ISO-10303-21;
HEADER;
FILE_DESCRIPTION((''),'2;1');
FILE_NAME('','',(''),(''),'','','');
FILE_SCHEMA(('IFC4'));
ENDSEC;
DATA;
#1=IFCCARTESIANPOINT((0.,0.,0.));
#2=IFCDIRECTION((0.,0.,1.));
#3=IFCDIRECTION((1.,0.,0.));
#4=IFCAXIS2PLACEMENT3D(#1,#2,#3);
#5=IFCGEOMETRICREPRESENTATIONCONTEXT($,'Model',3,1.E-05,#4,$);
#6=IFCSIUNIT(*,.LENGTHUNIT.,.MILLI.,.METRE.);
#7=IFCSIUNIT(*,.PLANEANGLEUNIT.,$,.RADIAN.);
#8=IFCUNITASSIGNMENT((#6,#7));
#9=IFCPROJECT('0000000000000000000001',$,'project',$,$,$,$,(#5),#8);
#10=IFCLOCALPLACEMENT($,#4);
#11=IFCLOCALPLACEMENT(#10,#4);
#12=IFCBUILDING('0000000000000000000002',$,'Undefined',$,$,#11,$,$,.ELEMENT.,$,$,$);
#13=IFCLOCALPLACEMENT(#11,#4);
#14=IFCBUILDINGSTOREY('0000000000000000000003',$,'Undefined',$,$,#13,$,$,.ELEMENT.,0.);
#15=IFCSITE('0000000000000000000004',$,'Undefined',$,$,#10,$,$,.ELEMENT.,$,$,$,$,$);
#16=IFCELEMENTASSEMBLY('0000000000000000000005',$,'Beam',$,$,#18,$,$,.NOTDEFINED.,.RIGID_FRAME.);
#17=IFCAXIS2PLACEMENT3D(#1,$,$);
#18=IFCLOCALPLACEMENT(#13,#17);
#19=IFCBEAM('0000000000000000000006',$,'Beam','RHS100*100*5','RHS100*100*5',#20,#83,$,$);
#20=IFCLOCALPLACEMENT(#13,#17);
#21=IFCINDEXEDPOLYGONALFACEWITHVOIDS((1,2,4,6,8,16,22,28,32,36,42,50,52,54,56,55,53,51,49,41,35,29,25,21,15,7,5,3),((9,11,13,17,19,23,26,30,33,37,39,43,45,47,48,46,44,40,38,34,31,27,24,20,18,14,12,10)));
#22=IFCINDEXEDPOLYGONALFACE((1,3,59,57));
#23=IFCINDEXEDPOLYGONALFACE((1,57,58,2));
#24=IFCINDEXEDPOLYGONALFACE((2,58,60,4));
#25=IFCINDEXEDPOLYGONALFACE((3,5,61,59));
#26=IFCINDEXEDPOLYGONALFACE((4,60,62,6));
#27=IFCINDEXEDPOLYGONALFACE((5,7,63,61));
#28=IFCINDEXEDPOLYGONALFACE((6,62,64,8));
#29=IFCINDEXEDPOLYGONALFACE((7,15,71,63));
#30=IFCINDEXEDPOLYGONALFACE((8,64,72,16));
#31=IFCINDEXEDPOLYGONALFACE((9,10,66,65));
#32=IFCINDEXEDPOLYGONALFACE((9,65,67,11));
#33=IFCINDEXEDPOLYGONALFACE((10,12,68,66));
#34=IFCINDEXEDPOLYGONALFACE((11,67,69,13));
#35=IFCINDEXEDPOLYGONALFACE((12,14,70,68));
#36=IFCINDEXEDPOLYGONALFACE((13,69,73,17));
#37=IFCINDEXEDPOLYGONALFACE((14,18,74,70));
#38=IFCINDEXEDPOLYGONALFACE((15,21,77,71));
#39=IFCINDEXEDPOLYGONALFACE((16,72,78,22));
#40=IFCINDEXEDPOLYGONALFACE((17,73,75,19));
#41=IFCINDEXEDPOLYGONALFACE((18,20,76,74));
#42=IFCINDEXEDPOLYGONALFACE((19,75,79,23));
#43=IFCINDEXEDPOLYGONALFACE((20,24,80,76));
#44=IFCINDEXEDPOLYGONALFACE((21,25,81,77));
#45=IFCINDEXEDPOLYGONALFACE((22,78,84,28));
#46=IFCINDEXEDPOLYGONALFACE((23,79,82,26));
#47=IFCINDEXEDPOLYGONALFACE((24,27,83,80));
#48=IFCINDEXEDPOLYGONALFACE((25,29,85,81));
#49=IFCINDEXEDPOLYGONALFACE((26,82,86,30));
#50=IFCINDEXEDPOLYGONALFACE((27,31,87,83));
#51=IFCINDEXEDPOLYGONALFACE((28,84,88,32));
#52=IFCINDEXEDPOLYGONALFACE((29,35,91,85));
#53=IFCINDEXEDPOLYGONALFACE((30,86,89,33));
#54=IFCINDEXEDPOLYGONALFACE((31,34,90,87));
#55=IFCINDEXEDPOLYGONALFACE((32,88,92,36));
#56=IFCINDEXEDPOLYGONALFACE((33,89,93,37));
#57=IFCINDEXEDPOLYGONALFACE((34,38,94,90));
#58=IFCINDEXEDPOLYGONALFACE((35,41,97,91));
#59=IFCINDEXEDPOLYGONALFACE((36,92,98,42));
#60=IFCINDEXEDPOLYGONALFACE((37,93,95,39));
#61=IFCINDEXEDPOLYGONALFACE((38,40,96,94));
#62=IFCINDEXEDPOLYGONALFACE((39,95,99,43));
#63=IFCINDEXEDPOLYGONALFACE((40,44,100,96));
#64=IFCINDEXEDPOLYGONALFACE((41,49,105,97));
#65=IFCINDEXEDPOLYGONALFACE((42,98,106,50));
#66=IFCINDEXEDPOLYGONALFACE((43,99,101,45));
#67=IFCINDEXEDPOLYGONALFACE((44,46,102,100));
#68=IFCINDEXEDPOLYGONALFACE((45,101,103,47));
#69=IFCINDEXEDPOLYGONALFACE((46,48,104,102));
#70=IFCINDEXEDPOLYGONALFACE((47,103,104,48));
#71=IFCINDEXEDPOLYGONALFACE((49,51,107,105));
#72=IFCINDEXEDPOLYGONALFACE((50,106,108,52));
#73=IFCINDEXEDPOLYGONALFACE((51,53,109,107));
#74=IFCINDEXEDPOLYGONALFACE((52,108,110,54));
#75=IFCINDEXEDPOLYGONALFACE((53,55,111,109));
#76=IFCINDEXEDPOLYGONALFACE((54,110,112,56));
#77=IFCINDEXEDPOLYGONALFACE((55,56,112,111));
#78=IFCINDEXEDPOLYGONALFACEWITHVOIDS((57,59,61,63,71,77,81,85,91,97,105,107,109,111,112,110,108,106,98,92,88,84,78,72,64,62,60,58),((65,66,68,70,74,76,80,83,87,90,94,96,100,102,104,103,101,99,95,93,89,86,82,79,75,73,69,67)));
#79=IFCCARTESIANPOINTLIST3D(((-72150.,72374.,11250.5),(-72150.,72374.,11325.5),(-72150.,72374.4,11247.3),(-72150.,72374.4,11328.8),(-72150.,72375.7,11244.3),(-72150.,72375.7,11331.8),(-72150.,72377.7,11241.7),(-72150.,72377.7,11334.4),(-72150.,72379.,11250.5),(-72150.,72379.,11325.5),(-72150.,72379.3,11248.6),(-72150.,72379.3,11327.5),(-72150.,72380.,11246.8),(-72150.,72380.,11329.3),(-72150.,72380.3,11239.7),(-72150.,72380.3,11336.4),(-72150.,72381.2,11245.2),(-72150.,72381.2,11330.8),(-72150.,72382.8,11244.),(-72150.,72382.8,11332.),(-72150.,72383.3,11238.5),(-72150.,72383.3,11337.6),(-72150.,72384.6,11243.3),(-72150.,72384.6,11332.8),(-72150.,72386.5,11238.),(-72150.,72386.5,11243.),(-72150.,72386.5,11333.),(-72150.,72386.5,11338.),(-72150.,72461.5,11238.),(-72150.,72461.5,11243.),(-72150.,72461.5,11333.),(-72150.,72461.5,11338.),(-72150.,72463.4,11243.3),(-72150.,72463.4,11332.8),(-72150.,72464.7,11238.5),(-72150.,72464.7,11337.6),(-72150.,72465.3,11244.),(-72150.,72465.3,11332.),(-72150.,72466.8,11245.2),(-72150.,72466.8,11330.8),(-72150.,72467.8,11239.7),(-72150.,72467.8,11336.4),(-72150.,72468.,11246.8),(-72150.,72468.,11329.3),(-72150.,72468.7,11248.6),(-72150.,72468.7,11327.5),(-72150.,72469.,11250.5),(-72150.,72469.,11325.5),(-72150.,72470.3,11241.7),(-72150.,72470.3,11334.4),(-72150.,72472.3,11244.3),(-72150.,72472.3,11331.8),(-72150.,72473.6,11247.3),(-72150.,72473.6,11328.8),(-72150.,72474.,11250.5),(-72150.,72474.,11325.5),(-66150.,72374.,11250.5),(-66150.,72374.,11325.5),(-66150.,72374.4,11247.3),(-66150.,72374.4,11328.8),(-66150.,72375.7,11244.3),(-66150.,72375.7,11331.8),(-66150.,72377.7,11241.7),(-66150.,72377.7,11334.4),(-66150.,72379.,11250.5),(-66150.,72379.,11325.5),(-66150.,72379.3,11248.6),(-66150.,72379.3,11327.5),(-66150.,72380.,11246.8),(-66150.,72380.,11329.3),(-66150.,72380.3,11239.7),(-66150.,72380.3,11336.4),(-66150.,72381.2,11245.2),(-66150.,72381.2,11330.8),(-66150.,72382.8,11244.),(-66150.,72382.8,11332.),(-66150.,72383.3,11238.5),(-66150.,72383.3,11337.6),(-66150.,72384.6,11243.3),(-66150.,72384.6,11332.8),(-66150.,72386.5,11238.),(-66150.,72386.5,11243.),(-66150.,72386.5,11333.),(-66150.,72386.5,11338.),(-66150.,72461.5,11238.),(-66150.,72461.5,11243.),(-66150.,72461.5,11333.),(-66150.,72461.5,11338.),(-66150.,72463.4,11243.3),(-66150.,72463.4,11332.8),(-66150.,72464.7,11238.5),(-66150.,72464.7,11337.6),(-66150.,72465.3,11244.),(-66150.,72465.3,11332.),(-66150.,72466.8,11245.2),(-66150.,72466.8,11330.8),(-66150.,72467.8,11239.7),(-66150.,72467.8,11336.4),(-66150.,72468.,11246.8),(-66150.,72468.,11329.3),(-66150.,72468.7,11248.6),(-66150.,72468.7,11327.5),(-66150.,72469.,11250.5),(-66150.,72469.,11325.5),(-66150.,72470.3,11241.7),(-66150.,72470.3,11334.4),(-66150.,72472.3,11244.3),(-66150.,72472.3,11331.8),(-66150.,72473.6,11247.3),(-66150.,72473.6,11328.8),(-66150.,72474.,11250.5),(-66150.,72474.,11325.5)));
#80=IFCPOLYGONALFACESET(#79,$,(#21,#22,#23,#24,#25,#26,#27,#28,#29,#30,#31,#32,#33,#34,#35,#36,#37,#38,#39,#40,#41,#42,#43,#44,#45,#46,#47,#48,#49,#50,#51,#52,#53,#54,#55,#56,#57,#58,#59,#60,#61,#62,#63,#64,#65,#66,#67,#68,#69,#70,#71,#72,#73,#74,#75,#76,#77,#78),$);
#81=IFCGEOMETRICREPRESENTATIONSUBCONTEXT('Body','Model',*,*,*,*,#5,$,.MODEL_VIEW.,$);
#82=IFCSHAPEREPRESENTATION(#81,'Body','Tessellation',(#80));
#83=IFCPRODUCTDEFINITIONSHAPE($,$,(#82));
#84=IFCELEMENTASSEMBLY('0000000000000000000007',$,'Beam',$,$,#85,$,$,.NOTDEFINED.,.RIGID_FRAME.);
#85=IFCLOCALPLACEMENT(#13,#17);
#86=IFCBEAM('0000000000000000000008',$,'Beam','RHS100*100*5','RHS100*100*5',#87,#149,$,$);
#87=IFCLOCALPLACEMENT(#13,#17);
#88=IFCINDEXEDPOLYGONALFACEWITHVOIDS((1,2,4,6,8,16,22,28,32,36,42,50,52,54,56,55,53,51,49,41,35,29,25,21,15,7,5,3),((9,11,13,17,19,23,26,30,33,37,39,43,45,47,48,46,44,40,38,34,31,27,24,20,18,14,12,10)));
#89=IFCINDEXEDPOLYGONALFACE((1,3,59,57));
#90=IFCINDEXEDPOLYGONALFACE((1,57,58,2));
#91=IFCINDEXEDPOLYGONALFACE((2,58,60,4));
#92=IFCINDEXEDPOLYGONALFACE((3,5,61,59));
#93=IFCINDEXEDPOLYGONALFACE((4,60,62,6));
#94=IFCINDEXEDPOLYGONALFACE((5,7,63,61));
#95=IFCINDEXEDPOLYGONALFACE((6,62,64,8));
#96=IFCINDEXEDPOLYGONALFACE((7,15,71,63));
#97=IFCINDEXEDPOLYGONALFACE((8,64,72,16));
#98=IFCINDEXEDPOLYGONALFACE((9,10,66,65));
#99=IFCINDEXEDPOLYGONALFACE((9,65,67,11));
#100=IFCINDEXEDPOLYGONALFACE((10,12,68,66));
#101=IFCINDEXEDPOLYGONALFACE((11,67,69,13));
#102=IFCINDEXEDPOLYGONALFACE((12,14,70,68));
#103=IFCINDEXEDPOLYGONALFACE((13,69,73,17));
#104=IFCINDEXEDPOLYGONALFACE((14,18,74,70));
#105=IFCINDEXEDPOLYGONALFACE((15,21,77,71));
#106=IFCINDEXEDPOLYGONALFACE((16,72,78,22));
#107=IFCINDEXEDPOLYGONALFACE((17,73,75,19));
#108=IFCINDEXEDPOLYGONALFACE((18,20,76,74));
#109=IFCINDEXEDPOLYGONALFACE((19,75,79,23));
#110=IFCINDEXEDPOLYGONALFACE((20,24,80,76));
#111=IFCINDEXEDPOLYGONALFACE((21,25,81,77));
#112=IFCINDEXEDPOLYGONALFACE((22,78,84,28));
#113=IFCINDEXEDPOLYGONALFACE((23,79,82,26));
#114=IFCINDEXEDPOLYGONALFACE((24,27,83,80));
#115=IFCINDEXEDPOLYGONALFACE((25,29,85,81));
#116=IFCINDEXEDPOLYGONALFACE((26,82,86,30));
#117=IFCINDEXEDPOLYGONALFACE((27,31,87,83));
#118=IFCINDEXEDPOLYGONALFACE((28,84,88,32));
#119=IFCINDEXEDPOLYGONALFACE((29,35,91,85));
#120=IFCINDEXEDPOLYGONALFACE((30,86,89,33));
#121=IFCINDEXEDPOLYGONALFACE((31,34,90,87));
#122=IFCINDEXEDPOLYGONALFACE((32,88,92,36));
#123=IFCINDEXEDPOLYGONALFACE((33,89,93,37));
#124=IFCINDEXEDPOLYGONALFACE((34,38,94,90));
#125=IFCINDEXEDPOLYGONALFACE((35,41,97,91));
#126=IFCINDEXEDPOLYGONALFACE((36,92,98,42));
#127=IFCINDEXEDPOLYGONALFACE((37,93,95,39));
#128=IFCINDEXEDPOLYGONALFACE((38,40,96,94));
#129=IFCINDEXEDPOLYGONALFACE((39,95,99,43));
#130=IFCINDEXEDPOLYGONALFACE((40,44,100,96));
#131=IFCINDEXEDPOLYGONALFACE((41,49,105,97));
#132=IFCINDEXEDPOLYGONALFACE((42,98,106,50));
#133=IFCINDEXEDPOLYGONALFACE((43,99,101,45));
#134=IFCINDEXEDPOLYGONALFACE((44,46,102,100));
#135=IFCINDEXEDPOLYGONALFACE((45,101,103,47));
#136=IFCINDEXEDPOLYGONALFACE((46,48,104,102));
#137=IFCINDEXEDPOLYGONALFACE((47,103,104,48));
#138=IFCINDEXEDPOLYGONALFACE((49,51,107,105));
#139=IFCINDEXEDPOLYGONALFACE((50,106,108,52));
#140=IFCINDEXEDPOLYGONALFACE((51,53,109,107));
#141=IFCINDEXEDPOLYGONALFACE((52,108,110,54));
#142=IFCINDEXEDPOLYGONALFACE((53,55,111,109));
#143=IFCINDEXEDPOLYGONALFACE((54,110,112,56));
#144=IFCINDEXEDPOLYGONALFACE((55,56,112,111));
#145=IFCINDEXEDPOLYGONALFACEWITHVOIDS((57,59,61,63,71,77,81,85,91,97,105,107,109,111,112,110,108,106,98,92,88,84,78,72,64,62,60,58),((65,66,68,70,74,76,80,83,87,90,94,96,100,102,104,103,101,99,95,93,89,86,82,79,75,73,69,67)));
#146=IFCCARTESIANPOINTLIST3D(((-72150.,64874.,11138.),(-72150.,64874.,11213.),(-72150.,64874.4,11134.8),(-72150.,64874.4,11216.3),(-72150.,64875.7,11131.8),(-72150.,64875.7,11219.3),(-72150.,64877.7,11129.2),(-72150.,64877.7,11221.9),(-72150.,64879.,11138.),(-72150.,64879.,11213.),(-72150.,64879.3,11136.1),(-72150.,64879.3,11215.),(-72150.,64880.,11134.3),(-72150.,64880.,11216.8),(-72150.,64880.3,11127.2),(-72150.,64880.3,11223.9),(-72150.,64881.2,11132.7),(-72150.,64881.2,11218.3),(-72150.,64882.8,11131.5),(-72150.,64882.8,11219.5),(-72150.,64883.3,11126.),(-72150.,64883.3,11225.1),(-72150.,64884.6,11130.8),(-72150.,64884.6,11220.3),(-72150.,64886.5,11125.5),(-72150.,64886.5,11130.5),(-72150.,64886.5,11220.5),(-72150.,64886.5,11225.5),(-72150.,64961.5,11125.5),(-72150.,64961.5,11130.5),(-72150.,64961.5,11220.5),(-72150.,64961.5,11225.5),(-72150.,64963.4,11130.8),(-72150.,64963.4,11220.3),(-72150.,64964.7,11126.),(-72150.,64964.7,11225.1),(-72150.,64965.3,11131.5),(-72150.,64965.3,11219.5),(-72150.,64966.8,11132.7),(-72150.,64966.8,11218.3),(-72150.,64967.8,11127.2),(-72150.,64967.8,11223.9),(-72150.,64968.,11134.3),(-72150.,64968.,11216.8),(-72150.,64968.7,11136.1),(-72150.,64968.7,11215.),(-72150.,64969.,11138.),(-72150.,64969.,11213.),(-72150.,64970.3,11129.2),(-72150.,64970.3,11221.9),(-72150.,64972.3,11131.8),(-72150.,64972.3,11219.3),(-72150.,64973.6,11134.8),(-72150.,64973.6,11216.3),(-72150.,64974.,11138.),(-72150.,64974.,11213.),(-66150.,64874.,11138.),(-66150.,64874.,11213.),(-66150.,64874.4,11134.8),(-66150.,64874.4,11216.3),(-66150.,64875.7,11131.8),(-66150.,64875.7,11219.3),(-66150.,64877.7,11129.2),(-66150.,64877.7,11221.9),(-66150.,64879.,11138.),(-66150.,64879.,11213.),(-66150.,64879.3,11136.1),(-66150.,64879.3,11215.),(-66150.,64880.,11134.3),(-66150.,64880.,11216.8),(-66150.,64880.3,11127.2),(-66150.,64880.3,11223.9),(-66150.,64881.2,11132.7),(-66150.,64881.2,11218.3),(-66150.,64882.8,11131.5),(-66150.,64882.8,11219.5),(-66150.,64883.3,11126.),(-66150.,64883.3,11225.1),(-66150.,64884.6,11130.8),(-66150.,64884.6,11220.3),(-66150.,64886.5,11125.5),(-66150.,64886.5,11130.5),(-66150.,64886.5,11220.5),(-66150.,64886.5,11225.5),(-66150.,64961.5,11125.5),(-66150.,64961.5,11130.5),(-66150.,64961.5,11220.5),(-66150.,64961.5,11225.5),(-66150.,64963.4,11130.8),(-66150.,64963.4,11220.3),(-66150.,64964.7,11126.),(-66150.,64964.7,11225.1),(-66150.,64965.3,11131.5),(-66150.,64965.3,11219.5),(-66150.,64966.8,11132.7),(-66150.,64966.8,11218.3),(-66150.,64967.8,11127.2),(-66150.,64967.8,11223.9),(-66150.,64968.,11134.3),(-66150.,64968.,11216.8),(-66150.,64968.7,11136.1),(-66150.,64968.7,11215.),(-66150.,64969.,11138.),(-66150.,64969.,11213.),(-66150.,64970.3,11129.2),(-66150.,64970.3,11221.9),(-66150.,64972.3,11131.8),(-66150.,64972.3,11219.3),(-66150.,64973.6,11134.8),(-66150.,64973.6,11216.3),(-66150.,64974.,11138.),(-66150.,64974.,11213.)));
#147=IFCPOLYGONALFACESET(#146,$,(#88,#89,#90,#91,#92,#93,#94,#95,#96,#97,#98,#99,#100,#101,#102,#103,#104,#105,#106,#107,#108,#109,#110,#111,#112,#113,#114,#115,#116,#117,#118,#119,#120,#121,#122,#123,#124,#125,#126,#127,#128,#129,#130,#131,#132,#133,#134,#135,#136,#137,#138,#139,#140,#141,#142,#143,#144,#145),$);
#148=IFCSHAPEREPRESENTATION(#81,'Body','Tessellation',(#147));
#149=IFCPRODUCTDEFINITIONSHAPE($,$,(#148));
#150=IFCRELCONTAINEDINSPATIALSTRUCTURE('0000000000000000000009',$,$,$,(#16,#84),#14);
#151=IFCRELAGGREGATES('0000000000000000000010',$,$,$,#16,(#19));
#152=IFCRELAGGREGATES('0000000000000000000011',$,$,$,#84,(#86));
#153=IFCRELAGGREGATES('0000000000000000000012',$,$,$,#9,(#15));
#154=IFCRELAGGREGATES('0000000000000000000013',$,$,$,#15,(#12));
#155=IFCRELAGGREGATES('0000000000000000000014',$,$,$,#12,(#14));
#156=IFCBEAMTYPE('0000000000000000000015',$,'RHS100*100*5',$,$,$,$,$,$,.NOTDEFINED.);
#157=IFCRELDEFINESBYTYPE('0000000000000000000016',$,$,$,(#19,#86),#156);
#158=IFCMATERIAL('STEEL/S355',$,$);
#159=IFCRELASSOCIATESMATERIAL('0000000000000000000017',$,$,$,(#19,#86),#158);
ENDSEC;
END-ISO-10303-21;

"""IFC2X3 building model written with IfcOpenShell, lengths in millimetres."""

from ifc_helpers import new_model, si_unit, frame, origin_with_axes, origin_2d_with_axis, place, context, subcontext, project, spatial, hollow_rectangle, extrude, material, type_object, element, aggregate, save


model = new_model("IFC2X3")

# Units and contexts
model_context = context("Model", 3, precision=1e-05, world=origin_with_axes())
body_context = subcontext(model_context, "Body", "Model", "MODEL_VIEW")
ifc_project = project(units=[si_unit("LENGTHUNIT", "METRE", prefix="MILLI"), si_unit("PLANEANGLEUNIT", "RADIAN")], contexts=[model_context])

# Site, building, storey
site_placement = place(None, origin_with_axes())
site = spatial("IfcSite", under=ifc_project, at=site_placement, Name="Undefined", CompositionType="ELEMENT")
building_placement = place(site_placement, origin_with_axes())
building = spatial("IfcBuilding", under=site, at=building_placement, Name="Undefined", CompositionType="ELEMENT")
storey_placement = place(building_placement, origin_with_axes())
storey = spatial("IfcBuildingStorey", under=building, at=storey_placement, Name="Undefined", CompositionType="ELEMENT", Elevation=0.0)

# Element assemblies, beams
ifc_material = material(Name="STEEL/S355")
beam_type_1 = type_object("IfcBeamType", Name="RHS100*100*5", PredefinedType="NOTDEFINED")
assembly_1_placement = place(storey_placement, origin_with_axes())
assembly_1 = element("IfcElementAssembly", 1, at=assembly_1_placement, inside=storey, Name="Beam", AssemblyPlace="NOTDEFINED", PredefinedType="RIGID_FRAME")
beam_1_placement = place(assembly_1_placement, frame((-66150.0, 72424.0, 11288.0), z_axis=(0.0, 0.0, 1.0), x_axis=(-1.0, 0.0, 0.0)))
beam_1 = element("IfcBeam", 2, at=beam_1_placement, type_object=beam_type_1, material=ifc_material, Name="Beam", Description="RHS100*100*5", ObjectType="RHS100*100*5", context=body_context, shape_type="SweptSolid", body=[
    extrude(hollow_rectangle(XDim=100.0, YDim=100.0, WallThickness=5.0, InnerFilletRadius=7.5, OuterFilletRadius=12.5, at=origin_2d_with_axis()), frame((6000.0, 0.0, 0.0), z_axis=(-1.0, 0.0, 0.0), x_axis=(0.0, -1.0, 0.0)), (0.0, 0.0, 1.0), 6000.0),
])
aggregate(assembly_1, [beam_1])
assembly_2_placement = place(storey_placement, origin_with_axes())
assembly_2 = element("IfcElementAssembly", 3, at=assembly_2_placement, inside=storey, Name="Beam", AssemblyPlace="NOTDEFINED", PredefinedType="RIGID_FRAME")
beam_2_placement = place(assembly_2_placement, frame((-66150.0, 64924.0, 11175.5), z_axis=(0.0, 0.0, 1.0), x_axis=(-1.0, 0.0, 0.0)))
beam_2 = element("IfcBeam", 4, at=beam_2_placement, type_object=beam_type_1, material=ifc_material, Name="Beam", Description="RHS100*100*5", ObjectType="RHS100*100*5", context=body_context, shape_type="SweptSolid", body=[
    extrude(hollow_rectangle(XDim=100.0, YDim=100.0, WallThickness=5.0, InnerFilletRadius=7.5, OuterFilletRadius=12.5, at=origin_2d_with_axis()), frame((6000.0, 0.0, 0.0), z_axis=(-1.0, 0.0, 0.0), x_axis=(0.0, -1.0, 0.0)), (0.0, 0.0, 1.0), 6000.0),
])
aggregate(assembly_2, [beam_2])

save(model, "model.ifc")
